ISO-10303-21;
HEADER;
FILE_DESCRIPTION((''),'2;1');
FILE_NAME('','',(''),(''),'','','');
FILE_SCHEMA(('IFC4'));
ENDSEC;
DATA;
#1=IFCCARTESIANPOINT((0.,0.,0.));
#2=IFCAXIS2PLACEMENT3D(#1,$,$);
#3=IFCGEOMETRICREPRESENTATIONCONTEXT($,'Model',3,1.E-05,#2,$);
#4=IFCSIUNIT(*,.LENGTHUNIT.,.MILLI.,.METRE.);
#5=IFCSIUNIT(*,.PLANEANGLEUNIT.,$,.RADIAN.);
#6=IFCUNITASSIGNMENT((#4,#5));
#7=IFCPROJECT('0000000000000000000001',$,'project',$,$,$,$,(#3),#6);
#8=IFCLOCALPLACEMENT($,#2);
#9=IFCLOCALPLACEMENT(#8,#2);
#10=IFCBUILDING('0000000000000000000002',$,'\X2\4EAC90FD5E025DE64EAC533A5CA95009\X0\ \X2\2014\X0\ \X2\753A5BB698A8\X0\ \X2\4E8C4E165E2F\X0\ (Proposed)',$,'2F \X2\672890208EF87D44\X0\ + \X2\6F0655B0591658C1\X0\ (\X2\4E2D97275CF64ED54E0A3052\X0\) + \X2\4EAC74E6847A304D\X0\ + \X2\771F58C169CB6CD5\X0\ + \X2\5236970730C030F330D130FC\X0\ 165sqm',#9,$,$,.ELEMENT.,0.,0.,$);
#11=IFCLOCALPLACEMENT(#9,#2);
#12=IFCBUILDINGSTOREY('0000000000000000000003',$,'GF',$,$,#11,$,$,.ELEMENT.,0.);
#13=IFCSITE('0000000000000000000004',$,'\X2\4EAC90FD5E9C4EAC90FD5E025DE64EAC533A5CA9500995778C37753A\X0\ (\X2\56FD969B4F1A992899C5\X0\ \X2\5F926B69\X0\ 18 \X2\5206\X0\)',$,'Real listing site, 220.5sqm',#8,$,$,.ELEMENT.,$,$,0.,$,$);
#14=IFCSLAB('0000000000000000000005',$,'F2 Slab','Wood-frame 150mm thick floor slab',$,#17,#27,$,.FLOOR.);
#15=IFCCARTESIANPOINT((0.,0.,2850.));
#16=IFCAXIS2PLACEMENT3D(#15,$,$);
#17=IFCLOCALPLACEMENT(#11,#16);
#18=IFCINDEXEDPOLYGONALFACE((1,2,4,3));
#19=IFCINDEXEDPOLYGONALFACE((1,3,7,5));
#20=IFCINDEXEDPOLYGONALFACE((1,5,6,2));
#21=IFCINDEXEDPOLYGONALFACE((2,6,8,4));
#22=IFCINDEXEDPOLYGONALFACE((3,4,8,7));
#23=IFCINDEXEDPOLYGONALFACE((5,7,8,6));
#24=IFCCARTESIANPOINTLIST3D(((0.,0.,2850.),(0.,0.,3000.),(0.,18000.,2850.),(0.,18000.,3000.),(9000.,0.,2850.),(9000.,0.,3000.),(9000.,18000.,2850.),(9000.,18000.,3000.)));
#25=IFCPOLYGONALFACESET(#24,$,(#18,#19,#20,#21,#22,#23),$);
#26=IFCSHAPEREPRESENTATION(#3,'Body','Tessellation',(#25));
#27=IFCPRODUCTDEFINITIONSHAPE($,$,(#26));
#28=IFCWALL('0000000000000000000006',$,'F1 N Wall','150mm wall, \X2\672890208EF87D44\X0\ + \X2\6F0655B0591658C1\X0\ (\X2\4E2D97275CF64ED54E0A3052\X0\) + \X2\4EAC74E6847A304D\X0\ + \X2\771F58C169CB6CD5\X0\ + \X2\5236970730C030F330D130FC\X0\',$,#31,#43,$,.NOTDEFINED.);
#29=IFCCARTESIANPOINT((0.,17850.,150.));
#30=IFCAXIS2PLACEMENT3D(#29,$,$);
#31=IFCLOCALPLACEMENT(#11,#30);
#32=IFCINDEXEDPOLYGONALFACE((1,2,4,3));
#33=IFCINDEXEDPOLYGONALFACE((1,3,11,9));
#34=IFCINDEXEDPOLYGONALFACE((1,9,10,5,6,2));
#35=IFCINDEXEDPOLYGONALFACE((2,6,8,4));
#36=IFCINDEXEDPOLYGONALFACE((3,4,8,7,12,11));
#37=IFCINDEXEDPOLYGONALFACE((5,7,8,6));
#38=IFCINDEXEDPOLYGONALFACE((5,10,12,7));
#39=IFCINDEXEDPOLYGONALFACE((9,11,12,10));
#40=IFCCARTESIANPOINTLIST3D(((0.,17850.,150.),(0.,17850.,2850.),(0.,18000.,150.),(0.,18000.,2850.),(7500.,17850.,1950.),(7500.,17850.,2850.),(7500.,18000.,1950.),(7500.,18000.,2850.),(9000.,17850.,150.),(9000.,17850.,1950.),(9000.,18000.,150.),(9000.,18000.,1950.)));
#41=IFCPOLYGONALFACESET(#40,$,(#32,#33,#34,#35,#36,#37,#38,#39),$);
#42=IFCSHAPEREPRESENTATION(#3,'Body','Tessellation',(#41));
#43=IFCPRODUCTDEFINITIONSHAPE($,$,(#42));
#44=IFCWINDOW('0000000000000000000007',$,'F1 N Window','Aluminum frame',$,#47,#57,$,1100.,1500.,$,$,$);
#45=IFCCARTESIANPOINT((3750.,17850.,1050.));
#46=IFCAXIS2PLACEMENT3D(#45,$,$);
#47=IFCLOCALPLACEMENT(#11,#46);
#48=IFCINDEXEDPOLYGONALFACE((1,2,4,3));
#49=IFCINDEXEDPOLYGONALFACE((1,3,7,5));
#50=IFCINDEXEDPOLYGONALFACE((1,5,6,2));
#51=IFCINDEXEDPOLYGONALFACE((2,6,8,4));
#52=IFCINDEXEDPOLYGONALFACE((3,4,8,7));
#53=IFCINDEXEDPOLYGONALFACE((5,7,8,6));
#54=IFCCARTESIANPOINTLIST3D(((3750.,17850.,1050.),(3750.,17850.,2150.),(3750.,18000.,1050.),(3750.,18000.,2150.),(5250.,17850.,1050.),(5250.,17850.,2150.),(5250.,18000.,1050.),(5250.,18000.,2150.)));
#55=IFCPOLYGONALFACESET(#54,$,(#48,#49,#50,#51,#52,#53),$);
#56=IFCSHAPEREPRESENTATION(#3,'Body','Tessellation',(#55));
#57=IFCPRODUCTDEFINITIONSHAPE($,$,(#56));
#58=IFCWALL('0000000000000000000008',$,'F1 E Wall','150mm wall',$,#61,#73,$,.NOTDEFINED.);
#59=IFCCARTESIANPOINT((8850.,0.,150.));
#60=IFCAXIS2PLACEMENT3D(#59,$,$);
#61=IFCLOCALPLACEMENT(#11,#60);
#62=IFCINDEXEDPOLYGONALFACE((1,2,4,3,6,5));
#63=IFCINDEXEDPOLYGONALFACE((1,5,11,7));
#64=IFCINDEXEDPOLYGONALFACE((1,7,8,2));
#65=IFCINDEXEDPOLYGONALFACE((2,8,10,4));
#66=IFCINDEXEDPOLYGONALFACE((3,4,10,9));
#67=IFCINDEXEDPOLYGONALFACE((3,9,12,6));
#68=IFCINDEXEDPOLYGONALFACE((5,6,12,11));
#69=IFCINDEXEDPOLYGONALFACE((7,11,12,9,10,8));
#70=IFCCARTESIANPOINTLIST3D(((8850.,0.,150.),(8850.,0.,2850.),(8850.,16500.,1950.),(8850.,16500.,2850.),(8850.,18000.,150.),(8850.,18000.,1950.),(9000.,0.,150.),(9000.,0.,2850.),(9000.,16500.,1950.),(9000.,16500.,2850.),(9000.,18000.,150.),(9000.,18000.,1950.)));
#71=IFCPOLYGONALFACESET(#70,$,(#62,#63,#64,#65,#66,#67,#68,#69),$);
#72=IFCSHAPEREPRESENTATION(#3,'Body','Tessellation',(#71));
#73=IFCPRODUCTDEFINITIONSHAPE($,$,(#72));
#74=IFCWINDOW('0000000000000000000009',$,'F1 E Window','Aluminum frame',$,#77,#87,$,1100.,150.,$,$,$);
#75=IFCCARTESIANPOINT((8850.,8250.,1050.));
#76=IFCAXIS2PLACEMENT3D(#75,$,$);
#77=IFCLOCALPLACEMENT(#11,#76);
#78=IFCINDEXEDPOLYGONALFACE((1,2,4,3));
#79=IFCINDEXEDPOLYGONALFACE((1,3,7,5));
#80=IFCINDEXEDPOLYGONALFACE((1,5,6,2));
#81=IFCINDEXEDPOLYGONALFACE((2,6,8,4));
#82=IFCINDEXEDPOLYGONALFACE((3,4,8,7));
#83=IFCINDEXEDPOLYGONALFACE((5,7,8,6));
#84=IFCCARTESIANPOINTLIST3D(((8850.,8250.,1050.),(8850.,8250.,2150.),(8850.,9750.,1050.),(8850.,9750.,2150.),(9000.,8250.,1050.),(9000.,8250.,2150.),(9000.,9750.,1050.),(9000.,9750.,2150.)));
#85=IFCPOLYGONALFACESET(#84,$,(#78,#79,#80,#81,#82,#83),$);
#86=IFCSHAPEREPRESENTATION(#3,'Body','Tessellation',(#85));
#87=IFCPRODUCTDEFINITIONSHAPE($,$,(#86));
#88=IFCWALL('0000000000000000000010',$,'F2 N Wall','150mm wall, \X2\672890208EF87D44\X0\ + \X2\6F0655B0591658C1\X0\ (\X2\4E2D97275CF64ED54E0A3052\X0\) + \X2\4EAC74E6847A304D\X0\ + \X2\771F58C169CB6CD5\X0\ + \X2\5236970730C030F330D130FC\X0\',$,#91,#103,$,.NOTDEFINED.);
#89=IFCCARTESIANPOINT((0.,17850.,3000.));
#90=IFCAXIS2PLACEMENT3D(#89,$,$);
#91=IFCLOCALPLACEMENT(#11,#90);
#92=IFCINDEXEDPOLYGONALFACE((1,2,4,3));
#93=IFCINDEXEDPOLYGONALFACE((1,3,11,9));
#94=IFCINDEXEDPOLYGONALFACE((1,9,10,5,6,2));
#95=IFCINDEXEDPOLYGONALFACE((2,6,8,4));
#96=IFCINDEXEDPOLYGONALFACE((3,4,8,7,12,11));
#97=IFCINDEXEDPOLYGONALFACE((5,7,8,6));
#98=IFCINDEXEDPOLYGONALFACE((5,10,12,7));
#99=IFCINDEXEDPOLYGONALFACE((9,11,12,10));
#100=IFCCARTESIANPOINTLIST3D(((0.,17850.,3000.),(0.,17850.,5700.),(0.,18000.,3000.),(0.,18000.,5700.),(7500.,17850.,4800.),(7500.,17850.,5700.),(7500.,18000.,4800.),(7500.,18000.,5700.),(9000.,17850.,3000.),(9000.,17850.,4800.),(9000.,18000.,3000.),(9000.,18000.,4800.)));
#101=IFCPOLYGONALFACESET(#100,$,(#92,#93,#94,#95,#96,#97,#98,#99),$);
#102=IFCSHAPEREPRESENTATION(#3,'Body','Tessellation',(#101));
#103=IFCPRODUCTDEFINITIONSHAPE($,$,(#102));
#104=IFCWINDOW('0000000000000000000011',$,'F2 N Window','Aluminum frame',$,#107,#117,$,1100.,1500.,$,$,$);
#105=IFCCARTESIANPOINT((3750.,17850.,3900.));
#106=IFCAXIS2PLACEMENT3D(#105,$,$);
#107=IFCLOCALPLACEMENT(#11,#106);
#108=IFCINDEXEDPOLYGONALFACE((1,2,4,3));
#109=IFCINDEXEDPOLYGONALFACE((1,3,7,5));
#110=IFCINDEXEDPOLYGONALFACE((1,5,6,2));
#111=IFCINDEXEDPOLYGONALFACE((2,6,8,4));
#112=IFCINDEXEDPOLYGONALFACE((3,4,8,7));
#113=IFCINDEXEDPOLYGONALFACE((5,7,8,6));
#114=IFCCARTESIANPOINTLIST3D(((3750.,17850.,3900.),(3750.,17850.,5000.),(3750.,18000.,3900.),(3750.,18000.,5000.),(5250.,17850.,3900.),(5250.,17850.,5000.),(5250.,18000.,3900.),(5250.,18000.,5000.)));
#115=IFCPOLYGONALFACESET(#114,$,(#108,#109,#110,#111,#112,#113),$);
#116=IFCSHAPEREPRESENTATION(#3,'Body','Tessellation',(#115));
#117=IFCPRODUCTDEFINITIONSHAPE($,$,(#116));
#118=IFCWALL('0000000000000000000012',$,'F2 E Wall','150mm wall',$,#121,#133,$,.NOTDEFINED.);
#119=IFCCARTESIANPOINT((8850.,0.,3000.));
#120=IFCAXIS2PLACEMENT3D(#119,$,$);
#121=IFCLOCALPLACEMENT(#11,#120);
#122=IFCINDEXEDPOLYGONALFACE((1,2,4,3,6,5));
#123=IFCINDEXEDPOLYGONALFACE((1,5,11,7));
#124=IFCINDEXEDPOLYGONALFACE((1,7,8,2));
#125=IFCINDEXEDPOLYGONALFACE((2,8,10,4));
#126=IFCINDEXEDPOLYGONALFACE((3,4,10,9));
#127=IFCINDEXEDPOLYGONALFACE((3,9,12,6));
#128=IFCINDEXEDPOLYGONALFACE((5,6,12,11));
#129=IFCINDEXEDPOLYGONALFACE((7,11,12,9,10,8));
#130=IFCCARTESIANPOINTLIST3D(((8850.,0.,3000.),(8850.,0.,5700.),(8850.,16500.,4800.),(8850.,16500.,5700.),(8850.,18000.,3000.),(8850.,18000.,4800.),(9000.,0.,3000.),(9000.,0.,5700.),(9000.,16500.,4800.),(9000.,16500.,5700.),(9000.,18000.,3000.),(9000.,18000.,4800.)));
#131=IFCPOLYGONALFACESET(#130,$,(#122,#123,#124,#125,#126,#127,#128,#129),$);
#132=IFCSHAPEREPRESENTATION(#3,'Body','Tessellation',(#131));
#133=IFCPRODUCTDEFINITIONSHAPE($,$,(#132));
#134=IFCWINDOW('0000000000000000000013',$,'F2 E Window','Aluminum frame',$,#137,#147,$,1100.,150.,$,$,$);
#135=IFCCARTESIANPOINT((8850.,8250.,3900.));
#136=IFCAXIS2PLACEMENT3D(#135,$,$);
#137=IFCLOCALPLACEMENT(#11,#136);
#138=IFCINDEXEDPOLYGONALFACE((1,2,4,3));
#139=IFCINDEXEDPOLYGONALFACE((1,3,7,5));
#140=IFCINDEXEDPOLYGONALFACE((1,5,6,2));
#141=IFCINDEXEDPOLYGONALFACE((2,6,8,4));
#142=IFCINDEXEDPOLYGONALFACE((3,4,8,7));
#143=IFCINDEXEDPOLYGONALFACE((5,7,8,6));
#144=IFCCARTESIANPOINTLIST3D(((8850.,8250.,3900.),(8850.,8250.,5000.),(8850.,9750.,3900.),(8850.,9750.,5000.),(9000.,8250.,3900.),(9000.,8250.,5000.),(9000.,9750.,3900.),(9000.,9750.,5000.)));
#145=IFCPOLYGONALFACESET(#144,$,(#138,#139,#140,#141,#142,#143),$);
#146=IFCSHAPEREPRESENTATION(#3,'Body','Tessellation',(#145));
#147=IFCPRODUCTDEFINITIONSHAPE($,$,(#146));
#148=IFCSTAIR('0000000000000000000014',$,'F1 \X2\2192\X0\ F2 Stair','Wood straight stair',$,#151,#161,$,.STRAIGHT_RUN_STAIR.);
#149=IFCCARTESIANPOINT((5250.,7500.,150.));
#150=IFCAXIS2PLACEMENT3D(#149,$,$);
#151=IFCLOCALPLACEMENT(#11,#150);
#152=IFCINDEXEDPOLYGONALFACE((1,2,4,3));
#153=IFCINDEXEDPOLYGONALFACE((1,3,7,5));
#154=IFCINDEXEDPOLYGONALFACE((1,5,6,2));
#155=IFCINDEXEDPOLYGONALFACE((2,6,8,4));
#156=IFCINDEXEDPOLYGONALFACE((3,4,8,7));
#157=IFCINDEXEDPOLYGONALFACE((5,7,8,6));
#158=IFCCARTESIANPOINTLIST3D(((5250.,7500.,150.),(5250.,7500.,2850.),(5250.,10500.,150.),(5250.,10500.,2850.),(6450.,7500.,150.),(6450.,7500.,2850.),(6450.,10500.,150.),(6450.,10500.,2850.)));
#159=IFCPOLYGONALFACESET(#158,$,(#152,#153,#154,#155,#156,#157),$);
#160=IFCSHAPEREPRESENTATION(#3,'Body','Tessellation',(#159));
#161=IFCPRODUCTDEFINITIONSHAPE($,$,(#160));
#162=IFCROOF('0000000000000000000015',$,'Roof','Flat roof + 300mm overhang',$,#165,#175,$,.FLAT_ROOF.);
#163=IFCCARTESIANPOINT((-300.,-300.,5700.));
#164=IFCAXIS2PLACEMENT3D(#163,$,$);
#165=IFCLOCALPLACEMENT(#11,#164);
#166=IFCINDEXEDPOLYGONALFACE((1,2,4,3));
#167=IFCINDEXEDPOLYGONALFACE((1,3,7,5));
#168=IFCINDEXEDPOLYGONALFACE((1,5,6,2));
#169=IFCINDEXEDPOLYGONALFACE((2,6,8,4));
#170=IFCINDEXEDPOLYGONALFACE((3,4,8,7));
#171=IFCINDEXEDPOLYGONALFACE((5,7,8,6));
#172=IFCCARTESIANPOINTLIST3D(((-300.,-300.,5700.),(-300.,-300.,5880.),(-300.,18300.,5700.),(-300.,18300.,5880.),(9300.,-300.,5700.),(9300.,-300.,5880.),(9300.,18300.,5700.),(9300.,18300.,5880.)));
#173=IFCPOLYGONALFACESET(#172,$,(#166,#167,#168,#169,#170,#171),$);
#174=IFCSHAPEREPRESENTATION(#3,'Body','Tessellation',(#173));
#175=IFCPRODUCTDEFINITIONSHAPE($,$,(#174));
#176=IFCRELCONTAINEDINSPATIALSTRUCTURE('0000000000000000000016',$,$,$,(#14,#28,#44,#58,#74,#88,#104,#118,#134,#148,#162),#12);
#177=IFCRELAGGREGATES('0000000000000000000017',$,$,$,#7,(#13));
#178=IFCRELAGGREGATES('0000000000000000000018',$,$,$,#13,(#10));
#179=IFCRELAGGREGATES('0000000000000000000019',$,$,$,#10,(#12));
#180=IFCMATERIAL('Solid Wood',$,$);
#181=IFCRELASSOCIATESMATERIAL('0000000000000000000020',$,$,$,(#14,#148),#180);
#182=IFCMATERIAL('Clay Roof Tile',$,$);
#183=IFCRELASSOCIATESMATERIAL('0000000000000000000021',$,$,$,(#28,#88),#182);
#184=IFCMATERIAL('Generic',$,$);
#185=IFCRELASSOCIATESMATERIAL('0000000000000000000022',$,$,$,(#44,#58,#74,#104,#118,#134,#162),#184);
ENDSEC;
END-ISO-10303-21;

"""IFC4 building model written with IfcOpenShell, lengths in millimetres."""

from ifc_helpers import new_model, si_unit, frame, frame_2d, origin, place, context, project, spatial, rectangle, extrude, material, element, fill, save


model = new_model("IFC4")

# Units and contexts
model_context = context("Model", 3, precision=1e-05, world=origin())
ifc_project = project(units=[si_unit("LENGTHUNIT", "METRE", prefix="MILLI"), si_unit("PLANEANGLEUNIT", "RADIAN")], contexts=[model_context])

# Site, building, storey
site_placement = place(None, origin())
site = spatial("IfcSite", under=ifc_project, at=site_placement, Name="京都府京都市左京区岩倉長谷町 (国際会館駅 徒歩 18 分)", ObjectType="Real listing site, 220.5sqm", CompositionType="ELEMENT", RefElevation=0.0)
building_placement = place(site_placement, origin())
building = spatial("IfcBuilding", under=site, at=building_placement, Name="京都市左京区岩倉 — 町家風 二世帯 (Proposed)", ObjectType="2F 木造軸組 + 漆喰外壁 (中霧島仕上げ) + 京瓦葺き + 真壁構法 + 制震ダンパー 165sqm", CompositionType="ELEMENT", ElevationOfRefHeight=0.0, ElevationOfTerrain=0.0)
storey_placement = place(building_placement, origin())
storey = spatial("IfcBuildingStorey", under=building, at=storey_placement, Name="GF", CompositionType="ELEMENT", Elevation=0.0)

# Slab
ifc_material_1 = material(Name="Solid Wood")
slab_1_placement = place(storey_placement, frame((0.0, 0.0, 2850.0)))
element("IfcSlab", 1, at=slab_1_placement, inside=storey, material=ifc_material_1, Name="F2 Slab", Description="Wood-frame 150mm thick floor slab", PredefinedType="FLOOR", context=model_context, shape_type="SweptSolid", body=[
    extrude(rectangle(XDim=9000.0, YDim=18000.0, at=frame_2d((4500.0, 9000.0))), frame((0.0, 0.0, 2850.0)), (0.0, 0.0, 1.0), 150.0),
])

# Wall, opening, window
ifc_material_2 = material(Name="Clay Roof Tile")
wall_1_placement = place(storey_placement, frame((0.0, 17850.0, 150.0)))
wall_1 = element("IfcWall", 2, at=wall_1_placement, inside=storey, material=ifc_material_2, Name="F1 N Wall", Description="150mm wall, 木造軸組 + 漆喰外壁 (中霧島仕上げ) + 京瓦葺き + 真壁構法 + 制震ダンパー", PredefinedType="NOTDEFINED", context=model_context, shape_type="SweptSolid", body=[
    extrude(rectangle(XDim=9000.0, YDim=150.0, at=frame_2d((4500.0, 75.0))), frame((0.0, 17850.0, 150.0)), (0.0, 0.0, 1.0), 2700.0),
])
opening_1_placement = place(storey_placement, frame((3750.0, 17850.0, 1050.0)))
opening_1 = element("IfcOpeningElement", 3, at=opening_1_placement, cuts=wall_1, PredefinedType="NOTDEFINED", context=model_context, shape_type="SweptSolid", body=[
    extrude(rectangle(XDim=1500.0, YDim=150.0, at=frame_2d((750.0, 75.0))), frame((3750.0, 17850.0, 1050.0)), (0.0, 0.0, 1.0), 1100.0),
])
ifc_material_3 = material(Name="Generic")
window_1_placement = place(storey_placement, frame((3750.0, 17850.0, 1050.0)))
window_1 = element("IfcWindow", 4, at=window_1_placement, inside=storey, material=ifc_material_3, Name="F1 N Window", Description="Aluminum frame", OverallHeight=1100.0, OverallWidth=1500.0, context=model_context, shape_type="SweptSolid", body=[
    extrude(rectangle(XDim=1500.0, YDim=150.0, at=frame_2d((750.0, 75.0))), frame((3750.0, 17850.0, 1050.0)), (0.0, 0.0, 1.0), 1100.0),
])
fill(opening_1, window_1)

# Walls, openings, windows
wall_2_placement = place(storey_placement, frame((8850.0, 0.0, 150.0)))
wall_2 = element("IfcWall", 5, at=wall_2_placement, inside=storey, material=ifc_material_3, Name="F1 E Wall", Description="150mm wall", PredefinedType="NOTDEFINED", context=model_context, shape_type="SweptSolid", body=[
    extrude(rectangle(XDim=150.0, YDim=18000.0, at=frame_2d((75.0, 9000.0))), frame((8850.0, 0.0, 150.0)), (0.0, 0.0, 1.0), 2700.0),
])
opening_2_placement = place(storey_placement, frame((8850.0, 8250.0, 1050.0)))
opening_2 = element("IfcOpeningElement", 6, at=opening_2_placement, cuts=wall_2, PredefinedType="NOTDEFINED", context=model_context, shape_type="SweptSolid", body=[
    extrude(rectangle(XDim=150.0, YDim=1500.0, at=frame_2d((75.0, 750.0))), frame((8850.0, 8250.0, 1050.0)), (0.0, 0.0, 1.0), 1100.0),
])
window_2_placement = place(storey_placement, frame((8850.0, 8250.0, 1050.0)))
window_2 = element("IfcWindow", 7, at=window_2_placement, inside=storey, material=ifc_material_3, Name="F1 E Window", Description="Aluminum frame", OverallHeight=1100.0, OverallWidth=150.0, context=model_context, shape_type="SweptSolid", body=[
    extrude(rectangle(XDim=150.0, YDim=1500.0, at=frame_2d((75.0, 750.0))), frame((8850.0, 8250.0, 1050.0)), (0.0, 0.0, 1.0), 1100.0),
])
fill(opening_2, window_2)
wall_3_placement = place(storey_placement, frame((0.0, 17850.0, 3000.0)))
wall_3 = element("IfcWall", 8, at=wall_3_placement, inside=storey, material=ifc_material_2, Name="F2 N Wall", Description="150mm wall, 木造軸組 + 漆喰外壁 (中霧島仕上げ) + 京瓦葺き + 真壁構法 + 制震ダンパー", PredefinedType="NOTDEFINED", context=model_context, shape_type="SweptSolid", body=[
    extrude(rectangle(XDim=9000.0, YDim=150.0, at=frame_2d((4500.0, 75.0))), frame((0.0, 17850.0, 3000.0)), (0.0, 0.0, 1.0), 2700.0),
])
opening_3_placement = place(storey_placement, frame((3750.0, 17850.0, 3900.0)))
opening_3 = element("IfcOpeningElement", 9, at=opening_3_placement, cuts=wall_3, PredefinedType="NOTDEFINED", context=model_context, shape_type="SweptSolid", body=[
    extrude(rectangle(XDim=1500.0, YDim=150.0, at=frame_2d((750.0, 75.0))), frame((3750.0, 17850.0, 3900.0)), (0.0, 0.0, 1.0), 1100.0),
])
window_3_placement = place(storey_placement, frame((3750.0, 17850.0, 3900.0)))
window_3 = element("IfcWindow", 10, at=window_3_placement, inside=storey, material=ifc_material_3, Name="F2 N Window", Description="Aluminum frame", OverallHeight=1100.0, OverallWidth=1500.0, context=model_context, shape_type="SweptSolid", body=[
    extrude(rectangle(XDim=1500.0, YDim=150.0, at=frame_2d((750.0, 75.0))), frame((3750.0, 17850.0, 3900.0)), (0.0, 0.0, 1.0), 1100.0),
])
fill(opening_3, window_3)
wall_4_placement = place(storey_placement, frame((8850.0, 0.0, 3000.0)))
wall_4 = element("IfcWall", 11, at=wall_4_placement, inside=storey, material=ifc_material_3, Name="F2 E Wall", Description="150mm wall", PredefinedType="NOTDEFINED", context=model_context, shape_type="SweptSolid", body=[
    extrude(rectangle(XDim=150.0, YDim=18000.0, at=frame_2d((75.0, 9000.0))), frame((8850.0, 0.0, 3000.0)), (0.0, 0.0, 1.0), 2700.0),
])
opening_4_placement = place(storey_placement, frame((8850.0, 8250.0, 3900.0)))
opening_4 = element("IfcOpeningElement", 12, at=opening_4_placement, cuts=wall_4, PredefinedType="NOTDEFINED", context=model_context, shape_type="SweptSolid", body=[
    extrude(rectangle(XDim=150.0, YDim=1500.0, at=frame_2d((75.0, 750.0))), frame((8850.0, 8250.0, 3900.0)), (0.0, 0.0, 1.0), 1100.0),
])
window_4_placement = place(storey_placement, frame((8850.0, 8250.0, 3900.0)))
window_4 = element("IfcWindow", 13, at=window_4_placement, inside=storey, material=ifc_material_3, Name="F2 E Window", Description="Aluminum frame", OverallHeight=1100.0, OverallWidth=150.0, context=model_context, shape_type="SweptSolid", body=[
    extrude(rectangle(XDim=150.0, YDim=1500.0, at=frame_2d((75.0, 750.0))), frame((8850.0, 8250.0, 3900.0)), (0.0, 0.0, 1.0), 1100.0),
])
fill(opening_4, window_4)

# Stair
stair_placement = place(storey_placement, frame((5250.0, 7500.0, 150.0)))
element("IfcStair", 14, at=stair_placement, inside=storey, material=ifc_material_1, Name="F1 → F2 Stair", Description="Wood straight stair", PredefinedType="STRAIGHT_RUN_STAIR", context=model_context, shape_type="SweptSolid", body=[
    extrude(rectangle(XDim=1200.0, YDim=3000.0, at=frame_2d((600.0, 1500.0))), frame((5250.0, 7500.0, 150.0)), (0.0, 0.0, 1.0), 2700.0),
])

# Roof
roof_placement = place(storey_placement, frame((-300.0, -300.0, 5700.0)))
element("IfcRoof", 15, at=roof_placement, inside=storey, material=ifc_material_3, Name="Roof", Description="Flat roof + 300mm overhang", PredefinedType="FLAT_ROOF", context=model_context, shape_type="SweptSolid", body=[
    extrude(rectangle(XDim=9600.0, YDim=18600.0, at=frame_2d((4800.0, 9300.0))), frame((-300.0, -300.0, 5700.0)), (0.0, 0.0, 1.0), 180.0),
])

save(model, "model.ifc")
